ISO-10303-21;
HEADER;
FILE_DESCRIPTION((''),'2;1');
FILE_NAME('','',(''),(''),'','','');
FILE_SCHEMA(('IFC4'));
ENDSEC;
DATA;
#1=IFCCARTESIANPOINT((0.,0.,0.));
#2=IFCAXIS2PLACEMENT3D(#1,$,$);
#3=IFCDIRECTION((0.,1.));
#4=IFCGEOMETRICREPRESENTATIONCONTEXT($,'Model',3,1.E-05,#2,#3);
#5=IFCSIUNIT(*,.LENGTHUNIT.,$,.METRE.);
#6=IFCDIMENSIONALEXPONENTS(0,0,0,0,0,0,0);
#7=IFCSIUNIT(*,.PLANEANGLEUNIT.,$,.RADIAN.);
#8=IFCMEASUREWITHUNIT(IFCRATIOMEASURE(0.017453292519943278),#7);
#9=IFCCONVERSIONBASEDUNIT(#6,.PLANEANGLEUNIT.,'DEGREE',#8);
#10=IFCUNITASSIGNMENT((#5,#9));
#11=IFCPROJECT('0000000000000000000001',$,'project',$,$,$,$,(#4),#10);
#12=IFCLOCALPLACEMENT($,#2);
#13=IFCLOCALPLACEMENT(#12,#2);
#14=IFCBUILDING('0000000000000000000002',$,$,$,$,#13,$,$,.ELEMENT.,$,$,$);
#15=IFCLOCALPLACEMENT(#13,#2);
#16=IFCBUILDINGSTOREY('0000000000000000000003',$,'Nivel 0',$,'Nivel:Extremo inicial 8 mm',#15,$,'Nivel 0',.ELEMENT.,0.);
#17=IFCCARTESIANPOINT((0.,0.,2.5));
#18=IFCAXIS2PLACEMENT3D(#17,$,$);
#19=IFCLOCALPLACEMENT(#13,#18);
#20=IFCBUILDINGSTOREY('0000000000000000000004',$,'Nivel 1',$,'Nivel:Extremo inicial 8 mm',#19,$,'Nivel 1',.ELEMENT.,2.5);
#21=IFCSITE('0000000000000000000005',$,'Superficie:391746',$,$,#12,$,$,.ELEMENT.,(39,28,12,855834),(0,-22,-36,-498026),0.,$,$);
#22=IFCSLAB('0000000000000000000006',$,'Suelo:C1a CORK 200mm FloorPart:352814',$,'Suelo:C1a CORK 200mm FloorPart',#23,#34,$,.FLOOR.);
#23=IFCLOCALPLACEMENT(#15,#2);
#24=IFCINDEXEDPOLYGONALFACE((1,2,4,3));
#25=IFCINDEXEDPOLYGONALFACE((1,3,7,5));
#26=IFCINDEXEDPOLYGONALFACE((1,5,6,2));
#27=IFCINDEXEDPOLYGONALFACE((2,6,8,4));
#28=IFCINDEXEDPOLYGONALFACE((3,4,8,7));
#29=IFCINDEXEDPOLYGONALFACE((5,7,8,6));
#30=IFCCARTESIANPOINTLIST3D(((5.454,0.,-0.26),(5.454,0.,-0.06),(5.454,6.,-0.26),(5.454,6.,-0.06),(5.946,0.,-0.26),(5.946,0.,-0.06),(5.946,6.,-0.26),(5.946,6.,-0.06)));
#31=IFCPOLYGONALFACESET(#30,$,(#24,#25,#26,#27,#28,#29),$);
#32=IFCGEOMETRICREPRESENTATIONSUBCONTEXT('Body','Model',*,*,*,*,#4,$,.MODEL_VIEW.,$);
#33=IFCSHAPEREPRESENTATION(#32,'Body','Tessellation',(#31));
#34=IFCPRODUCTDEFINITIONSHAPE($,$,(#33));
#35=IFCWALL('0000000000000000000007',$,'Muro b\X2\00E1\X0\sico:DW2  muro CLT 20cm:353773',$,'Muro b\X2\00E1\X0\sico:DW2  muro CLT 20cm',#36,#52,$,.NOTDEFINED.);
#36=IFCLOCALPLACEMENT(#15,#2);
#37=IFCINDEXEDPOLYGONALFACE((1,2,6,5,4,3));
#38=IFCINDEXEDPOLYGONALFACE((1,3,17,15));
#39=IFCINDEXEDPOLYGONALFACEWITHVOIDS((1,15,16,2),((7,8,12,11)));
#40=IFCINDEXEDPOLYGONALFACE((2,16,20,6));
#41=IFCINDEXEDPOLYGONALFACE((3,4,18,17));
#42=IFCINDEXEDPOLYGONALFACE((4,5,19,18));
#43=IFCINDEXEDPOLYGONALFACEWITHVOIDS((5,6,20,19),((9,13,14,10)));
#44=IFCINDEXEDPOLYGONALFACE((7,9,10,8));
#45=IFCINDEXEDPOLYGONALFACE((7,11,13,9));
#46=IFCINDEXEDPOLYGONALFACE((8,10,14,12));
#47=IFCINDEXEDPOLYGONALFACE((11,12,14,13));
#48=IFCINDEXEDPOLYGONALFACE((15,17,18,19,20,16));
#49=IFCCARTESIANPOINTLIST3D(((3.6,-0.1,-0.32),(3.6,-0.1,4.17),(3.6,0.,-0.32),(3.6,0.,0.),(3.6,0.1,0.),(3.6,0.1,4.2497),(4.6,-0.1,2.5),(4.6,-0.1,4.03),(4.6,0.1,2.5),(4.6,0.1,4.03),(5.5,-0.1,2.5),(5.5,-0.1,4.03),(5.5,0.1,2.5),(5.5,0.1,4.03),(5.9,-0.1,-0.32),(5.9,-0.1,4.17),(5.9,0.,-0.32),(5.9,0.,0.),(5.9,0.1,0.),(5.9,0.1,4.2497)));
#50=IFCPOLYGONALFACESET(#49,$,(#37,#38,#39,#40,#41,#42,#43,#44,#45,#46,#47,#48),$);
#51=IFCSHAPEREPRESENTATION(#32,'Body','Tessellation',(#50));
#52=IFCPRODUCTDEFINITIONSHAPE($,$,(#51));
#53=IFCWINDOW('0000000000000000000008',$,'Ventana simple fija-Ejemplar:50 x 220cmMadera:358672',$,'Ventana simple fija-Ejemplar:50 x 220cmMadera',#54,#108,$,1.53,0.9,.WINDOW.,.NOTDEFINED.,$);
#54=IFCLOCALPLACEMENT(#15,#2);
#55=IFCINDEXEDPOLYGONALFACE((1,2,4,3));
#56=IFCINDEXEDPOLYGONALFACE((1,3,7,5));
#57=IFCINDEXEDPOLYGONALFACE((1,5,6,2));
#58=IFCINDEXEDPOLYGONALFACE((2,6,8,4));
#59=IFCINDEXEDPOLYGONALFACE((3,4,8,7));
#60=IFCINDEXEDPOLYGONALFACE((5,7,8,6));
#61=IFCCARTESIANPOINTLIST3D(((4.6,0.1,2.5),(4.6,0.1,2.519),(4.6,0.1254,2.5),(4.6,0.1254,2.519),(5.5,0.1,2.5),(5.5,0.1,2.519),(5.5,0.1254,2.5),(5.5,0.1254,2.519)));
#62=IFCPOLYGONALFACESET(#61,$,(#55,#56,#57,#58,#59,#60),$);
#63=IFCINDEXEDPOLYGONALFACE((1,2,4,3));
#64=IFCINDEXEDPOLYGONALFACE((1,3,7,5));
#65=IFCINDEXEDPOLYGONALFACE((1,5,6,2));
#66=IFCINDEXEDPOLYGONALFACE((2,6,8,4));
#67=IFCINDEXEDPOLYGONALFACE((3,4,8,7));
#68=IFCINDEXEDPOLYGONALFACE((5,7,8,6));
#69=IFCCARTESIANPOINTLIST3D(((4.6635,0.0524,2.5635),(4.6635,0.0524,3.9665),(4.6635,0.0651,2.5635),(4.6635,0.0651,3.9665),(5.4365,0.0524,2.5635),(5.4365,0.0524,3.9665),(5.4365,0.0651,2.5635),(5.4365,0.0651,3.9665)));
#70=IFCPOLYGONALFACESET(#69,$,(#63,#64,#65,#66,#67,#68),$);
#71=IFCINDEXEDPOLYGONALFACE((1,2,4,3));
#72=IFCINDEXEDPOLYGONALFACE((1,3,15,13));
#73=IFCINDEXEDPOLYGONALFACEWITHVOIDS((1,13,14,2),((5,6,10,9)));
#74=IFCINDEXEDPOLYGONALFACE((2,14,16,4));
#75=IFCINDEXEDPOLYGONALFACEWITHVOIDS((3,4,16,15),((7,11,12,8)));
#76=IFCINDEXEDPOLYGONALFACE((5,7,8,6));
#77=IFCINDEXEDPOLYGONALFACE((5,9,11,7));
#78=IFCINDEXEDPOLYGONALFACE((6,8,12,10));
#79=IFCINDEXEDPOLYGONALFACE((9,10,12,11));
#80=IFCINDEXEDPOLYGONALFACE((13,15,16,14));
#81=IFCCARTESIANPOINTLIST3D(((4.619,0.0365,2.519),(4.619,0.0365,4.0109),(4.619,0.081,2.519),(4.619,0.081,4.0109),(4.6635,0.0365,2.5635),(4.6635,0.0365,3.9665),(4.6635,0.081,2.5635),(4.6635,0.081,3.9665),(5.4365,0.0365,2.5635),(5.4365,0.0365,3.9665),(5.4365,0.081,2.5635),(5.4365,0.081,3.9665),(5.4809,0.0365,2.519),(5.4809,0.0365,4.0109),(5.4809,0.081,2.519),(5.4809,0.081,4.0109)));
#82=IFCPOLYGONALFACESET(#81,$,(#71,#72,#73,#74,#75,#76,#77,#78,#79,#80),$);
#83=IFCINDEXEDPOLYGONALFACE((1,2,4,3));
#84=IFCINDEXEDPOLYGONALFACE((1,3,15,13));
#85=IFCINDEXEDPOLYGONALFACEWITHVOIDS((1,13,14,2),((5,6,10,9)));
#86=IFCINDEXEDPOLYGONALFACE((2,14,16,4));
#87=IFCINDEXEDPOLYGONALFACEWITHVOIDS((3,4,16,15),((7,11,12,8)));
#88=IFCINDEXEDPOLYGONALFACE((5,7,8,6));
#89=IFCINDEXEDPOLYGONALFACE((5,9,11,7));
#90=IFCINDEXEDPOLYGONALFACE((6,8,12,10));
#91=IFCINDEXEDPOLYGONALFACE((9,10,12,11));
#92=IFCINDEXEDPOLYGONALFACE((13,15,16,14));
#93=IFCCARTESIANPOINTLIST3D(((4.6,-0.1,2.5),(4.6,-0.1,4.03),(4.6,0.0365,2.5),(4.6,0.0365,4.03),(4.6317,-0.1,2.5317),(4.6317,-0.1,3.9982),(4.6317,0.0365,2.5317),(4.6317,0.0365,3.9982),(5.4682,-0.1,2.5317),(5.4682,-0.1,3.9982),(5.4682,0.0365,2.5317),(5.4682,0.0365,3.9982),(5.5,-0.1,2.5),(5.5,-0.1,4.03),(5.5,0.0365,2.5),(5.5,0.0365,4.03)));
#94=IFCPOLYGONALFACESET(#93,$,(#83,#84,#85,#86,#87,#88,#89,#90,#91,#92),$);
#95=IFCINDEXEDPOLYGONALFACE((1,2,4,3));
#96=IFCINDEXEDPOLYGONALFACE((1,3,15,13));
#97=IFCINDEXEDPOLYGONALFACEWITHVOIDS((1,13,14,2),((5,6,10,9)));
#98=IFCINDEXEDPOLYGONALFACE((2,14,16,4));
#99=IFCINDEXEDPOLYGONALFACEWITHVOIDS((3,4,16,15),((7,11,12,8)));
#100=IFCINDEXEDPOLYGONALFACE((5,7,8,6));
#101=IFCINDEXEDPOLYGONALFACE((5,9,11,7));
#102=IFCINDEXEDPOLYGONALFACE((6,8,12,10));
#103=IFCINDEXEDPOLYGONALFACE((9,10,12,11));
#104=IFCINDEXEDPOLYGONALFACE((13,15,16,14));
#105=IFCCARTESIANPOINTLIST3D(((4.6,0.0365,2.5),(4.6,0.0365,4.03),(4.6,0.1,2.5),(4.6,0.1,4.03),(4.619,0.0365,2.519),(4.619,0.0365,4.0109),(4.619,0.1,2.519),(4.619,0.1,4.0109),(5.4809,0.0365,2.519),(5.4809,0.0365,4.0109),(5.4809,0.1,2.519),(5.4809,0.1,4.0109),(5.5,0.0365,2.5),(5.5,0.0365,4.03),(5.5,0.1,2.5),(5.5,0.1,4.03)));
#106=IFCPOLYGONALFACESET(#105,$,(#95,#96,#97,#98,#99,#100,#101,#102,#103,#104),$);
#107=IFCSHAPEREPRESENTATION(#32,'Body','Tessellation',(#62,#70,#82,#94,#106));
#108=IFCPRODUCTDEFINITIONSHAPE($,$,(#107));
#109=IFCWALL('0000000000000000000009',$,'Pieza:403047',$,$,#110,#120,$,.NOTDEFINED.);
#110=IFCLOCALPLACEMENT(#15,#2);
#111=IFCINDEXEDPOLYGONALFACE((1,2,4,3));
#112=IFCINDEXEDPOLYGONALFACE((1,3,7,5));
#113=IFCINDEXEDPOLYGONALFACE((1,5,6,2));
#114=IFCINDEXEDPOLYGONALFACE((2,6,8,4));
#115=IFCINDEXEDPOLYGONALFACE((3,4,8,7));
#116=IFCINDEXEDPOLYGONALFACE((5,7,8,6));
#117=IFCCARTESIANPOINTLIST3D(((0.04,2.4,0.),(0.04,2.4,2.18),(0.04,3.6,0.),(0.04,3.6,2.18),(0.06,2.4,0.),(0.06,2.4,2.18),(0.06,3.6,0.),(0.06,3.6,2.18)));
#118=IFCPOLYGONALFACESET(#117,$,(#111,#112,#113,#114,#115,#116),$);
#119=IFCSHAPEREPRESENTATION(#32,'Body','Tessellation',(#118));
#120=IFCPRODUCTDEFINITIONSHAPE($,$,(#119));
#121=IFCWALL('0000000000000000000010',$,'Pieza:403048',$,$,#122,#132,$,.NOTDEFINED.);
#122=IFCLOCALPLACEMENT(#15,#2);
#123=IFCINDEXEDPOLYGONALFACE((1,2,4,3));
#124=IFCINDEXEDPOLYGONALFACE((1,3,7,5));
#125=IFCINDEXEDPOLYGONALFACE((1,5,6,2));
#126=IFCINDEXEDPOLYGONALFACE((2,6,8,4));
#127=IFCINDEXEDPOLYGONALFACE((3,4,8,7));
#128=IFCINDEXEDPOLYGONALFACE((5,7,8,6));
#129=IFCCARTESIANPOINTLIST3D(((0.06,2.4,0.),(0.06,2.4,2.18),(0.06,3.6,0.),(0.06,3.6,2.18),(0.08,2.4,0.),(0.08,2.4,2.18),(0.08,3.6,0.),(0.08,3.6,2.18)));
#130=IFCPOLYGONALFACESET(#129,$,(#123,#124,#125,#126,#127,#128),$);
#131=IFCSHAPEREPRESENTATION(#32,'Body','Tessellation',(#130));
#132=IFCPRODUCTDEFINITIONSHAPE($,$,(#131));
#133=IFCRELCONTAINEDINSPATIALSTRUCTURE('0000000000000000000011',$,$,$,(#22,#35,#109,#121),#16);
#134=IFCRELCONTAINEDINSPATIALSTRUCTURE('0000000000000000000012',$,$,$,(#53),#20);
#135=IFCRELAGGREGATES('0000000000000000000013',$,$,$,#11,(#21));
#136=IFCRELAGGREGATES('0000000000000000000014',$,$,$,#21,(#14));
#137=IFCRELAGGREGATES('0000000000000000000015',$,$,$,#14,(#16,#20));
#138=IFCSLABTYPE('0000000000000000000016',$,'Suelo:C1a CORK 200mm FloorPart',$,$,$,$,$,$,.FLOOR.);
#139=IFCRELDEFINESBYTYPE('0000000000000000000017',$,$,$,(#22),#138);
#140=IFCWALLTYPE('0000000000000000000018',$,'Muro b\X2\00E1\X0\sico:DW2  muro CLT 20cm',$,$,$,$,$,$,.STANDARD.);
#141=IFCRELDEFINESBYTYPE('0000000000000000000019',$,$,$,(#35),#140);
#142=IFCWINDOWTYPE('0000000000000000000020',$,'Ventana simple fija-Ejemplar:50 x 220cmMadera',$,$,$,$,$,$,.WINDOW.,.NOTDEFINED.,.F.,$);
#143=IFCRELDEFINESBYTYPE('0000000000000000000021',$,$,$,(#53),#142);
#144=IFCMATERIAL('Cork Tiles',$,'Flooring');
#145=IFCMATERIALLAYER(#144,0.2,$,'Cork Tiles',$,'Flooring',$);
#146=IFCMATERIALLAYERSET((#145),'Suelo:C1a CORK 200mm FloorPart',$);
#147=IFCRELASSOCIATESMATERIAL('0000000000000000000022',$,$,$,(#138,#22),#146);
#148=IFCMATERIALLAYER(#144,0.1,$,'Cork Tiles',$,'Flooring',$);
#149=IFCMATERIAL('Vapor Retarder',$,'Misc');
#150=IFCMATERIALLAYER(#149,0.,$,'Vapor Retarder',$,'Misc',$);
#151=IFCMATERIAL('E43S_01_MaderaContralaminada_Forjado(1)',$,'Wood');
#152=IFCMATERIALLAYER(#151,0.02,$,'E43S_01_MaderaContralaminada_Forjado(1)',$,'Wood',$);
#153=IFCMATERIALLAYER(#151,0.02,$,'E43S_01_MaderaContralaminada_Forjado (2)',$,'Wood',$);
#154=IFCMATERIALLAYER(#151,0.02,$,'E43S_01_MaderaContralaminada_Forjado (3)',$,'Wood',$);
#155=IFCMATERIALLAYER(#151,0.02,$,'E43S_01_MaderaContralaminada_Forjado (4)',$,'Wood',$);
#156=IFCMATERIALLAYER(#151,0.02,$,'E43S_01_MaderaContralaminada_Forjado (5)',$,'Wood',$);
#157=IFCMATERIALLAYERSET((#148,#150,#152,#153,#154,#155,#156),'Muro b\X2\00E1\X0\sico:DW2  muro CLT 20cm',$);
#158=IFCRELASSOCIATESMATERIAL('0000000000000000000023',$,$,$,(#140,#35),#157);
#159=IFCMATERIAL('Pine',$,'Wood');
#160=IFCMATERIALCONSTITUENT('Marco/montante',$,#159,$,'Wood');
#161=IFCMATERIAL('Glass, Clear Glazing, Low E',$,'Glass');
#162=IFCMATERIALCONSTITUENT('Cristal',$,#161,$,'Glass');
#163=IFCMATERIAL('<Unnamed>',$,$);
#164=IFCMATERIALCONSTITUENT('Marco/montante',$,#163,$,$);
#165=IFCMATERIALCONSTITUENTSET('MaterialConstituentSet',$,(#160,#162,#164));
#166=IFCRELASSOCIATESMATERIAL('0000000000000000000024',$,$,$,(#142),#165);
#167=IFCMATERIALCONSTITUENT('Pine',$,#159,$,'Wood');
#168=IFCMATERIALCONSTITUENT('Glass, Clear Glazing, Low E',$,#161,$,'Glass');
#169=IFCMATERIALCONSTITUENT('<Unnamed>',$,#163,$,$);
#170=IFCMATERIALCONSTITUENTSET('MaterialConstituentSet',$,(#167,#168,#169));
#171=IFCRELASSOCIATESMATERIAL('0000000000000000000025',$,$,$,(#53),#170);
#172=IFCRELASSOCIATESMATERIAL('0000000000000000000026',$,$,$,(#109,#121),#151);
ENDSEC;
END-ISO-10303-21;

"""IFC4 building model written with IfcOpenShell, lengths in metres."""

from ifc_helpers import new_model, entity, si_unit, converted_unit, direction, frame, frame_2d, origin, origin_2d_with_axis, place, context, subcontext, project, spatial, polyline, rectangle, outline, extrude, clip, bounded_halfspace, source, transform, mapped, material, layer, layer_set, layer_usage, constituent, constituent_set, type_object, type_shapes, element, fill, save


model = new_model("IFC4")

# Units and contexts
model_context = context("Model", 3, precision=1e-05, world=origin(), true_north=direction((0.0, 1.0)))
body_context = subcontext(model_context, "Body", "Model", "MODEL_VIEW")
ifc_project = project(units=[si_unit("LENGTHUNIT", "METRE"), converted_unit("PLANEANGLEUNIT", "DEGREE", entity("IfcRatioMeasure", 0.017453292519943278), si_unit("PLANEANGLEUNIT", "RADIAN"), dimensions=[0, 0, 0, 0, 0, 0, 0])], contexts=[model_context])

# Site, building, storey
site_placement = place(None, origin())
site = spatial("IfcSite", under=ifc_project, at=site_placement, Name="Superficie:391746", CompositionType="ELEMENT", RefLatitude=(39, 28, 12, 855834), RefLongitude=(0, -22, -36, -498026), RefElevation=0.0)
building_placement = place(site_placement, origin())
building = spatial("IfcBuilding", under=site, at=building_placement, CompositionType="ELEMENT")
storey_1_placement = place(building_placement, origin())
storey_1 = spatial("IfcBuildingStorey", under=building, at=storey_1_placement, Name="Nivel 0", ObjectType="Nivel:Extremo inicial 8 mm", LongName="Nivel 0", CompositionType="ELEMENT", Elevation=0.0)

# Slab
ifc_material_1 = material(Name="E43S_01_MaderaContralaminada_Forjado(1)", Category="Wood")
ifc_material_2 = material(Name="Cork Tiles", Category="Flooring")
ifc_layer_1 = layer(ifc_material_2, 0.2, Name="Cork Tiles", Category="Flooring")
ifc_layer_set_1 = layer_set([ifc_layer_1], Name="Suelo:C1a CORK 200mm FloorPart")
ifc_layer_usage_1 = layer_usage(ifc_layer_set_1, "AXIS3", "POSITIVE", 0.0)
slab_type_1 = type_object("IfcSlabType", Name="Suelo:C1a CORK 200mm FloorPart", PredefinedType="FLOOR", material=ifc_layer_set_1)
slab_1_placement = place(storey_1_placement, origin())
element("IfcSlab", 1, at=slab_1_placement, inside=storey_1, type_object=slab_type_1, material=ifc_layer_usage_1, Name="Suelo:C1a CORK 200mm FloorPart:352814", ObjectType="Suelo:C1a CORK 200mm FloorPart", PredefinedType="FLOOR", context=body_context, shape_type="SweptSolid", body=[
    extrude(rectangle(XDim=6.0, YDim=0.492, at=frame_2d((0.0, 0.0), x_axis=(1.0, 0.0))), frame((5.7, 3.0, -0.06), z_axis=(0.0, 0.0, -1.0), x_axis=(0.0, 1.0, 0.0)), (0.0, 0.0, 1.0), 0.2),
])

# Wall, openings
ifc_layer_2 = layer(ifc_material_2, 0.1, Name="Cork Tiles", Category="Flooring")
ifc_material_3 = material(Name="Vapor Retarder", Category="Misc")
ifc_layer_3 = layer(ifc_material_3, 0.0, Name="Vapor Retarder", Category="Misc")
ifc_layer_4 = layer(ifc_material_1, 0.02, Name="E43S_01_MaderaContralaminada_Forjado(1)", Category="Wood")
ifc_layer_5 = layer(ifc_material_1, 0.02, Name="E43S_01_MaderaContralaminada_Forjado (2)", Category="Wood")
ifc_layer_6 = layer(ifc_material_1, 0.02, Name="E43S_01_MaderaContralaminada_Forjado (3)", Category="Wood")
ifc_layer_7 = layer(ifc_material_1, 0.02, Name="E43S_01_MaderaContralaminada_Forjado (4)", Category="Wood")
ifc_layer_8 = layer(ifc_material_1, 0.02, Name="E43S_01_MaderaContralaminada_Forjado (5)", Category="Wood")
ifc_layer_set_2 = layer_set([ifc_layer_2, ifc_layer_3, ifc_layer_4, ifc_layer_5, ifc_layer_6, ifc_layer_7, ifc_layer_8], Name="Muro básico:DW2  muro CLT 20cm")
ifc_layer_usage_2 = layer_usage(ifc_layer_set_2, "AXIS2", "NEGATIVE", 0.1)
wall_type = type_object("IfcWallType", Name="Muro básico:DW2  muro CLT 20cm", PredefinedType="STANDARD", material=ifc_layer_set_2)
wall_1_placement = place(storey_1_placement, frame((5.9, 0.0, -0.32), z_axis=(0.0, 0.0, 1.0), x_axis=(-1.0, 0.0, 0.0)))
wall_1 = element("IfcWall", 2, at=wall_1_placement, inside=storey_1, type_object=wall_type, material=ifc_layer_usage_2, Name="Muro básico:DW2  muro CLT 20cm:353773", ObjectType="Muro básico:DW2  muro CLT 20cm", PredefinedType="NOTDEFINED", context=body_context, shape_type="Clipping", body=[
    clip(clip(extrude(rectangle(XDim=2.3, YDim=0.2, at=frame_2d((1.15, 0.0), x_axis=(1.0, 0.0))), origin(), (0.0, 0.0, 1.0), 4.5697), bounded_halfspace(frame((0.0, -0.1, 4.5697), z_axis=(0.0, 0.370288, 0.928917), x_axis=(-1.0, 0.0, 0.0)), False, frame((0.0, -0.1, 4.5697)), polyline([(0.0, 0.0), (2.3, 0.0), (2.3, 0.2), (0.0, 0.2), (0.0, 0.0)]))), bounded_halfspace(frame((2.3, -0.1, 0.32), z_axis=(0.0, 0.0, -1.0), x_axis=(0.0, 1.0, 0.0)), False, frame((2.3, -0.1, 0.32)), polyline([(0.0, 0.0), (0.0, 0.1), (-2.3, 0.1), (-2.3, 0.0), (0.0, 0.0)]))),
])
opening_1_placement = place(wall_1_placement, frame((5.4, 1.624, 0.32)))
element("IfcOpeningElement", 3, at=opening_1_placement, cuts=wall_1, PredefinedType="OPENING", context=body_context, shape_type="SweptSolid", body=[
    extrude(rectangle(XDim=2.1, YDim=1.4, at=origin_2d_with_axis()), frame((-0.7, -3.048, 1.05), z_axis=(0.0, 1.0, 0.0), x_axis=(0.0, 0.0, -1.0)), (0.0, 0.0, 1.0), 3.048),
])
opening_2_placement = place(wall_1_placement, frame((1.3, 0.1, 2.82)))
opening_2 = element("IfcOpeningElement", 4, at=opening_2_placement, cuts=wall_1, PredefinedType="OPENING", context=body_context, shape_type="SweptSolid", body=[
    extrude(rectangle(XDim=1.53, YDim=0.9, at=frame_2d((0.765, 0.45), x_axis=(-1.0, 0.0))), frame((0.0, 0.0, 0.0), z_axis=(0.0, -1.0, 0.0), x_axis=(0.0, 0.0, 1.0)), (0.0, 0.0, 1.0), 0.2),
])

# Shared definitions
storey_2_placement = place(building_placement, frame((0.0, 0.0, 2.5)))
storey_2 = spatial("IfcBuildingStorey", under=building, at=storey_2_placement, Name="Nivel 1", ObjectType="Nivel:Extremo inicial 8 mm", LongName="Nivel 1", CompositionType="ELEMENT", Elevation=2.5)

# Window
ifc_material_4 = material(Name="Pine", Category="Wood")
ifc_constituent_1 = constituent(ifc_material_4, Name="Pine", Category="Wood")
ifc_material_5 = material(Name="Glass, Clear Glazing, Low E", Category="Glass")
ifc_constituent_2 = constituent(ifc_material_5, Name="Glass, Clear Glazing, Low E", Category="Glass")
ifc_material_6 = material(Name="<Unnamed>")
ifc_constituent_3 = constituent(ifc_material_6, Name="<Unnamed>")
ifc_constituent_set_1 = constituent_set(constituents=[ifc_constituent_1, ifc_constituent_2, ifc_constituent_3], Name="MaterialConstituentSet")
ifc_constituent_4 = constituent(ifc_material_4, Name="Marco/montante", Category="Wood")
ifc_constituent_5 = constituent(ifc_material_5, Name="Cristal", Category="Glass")
ifc_constituent_6 = constituent(ifc_material_6, Name="Marco/montante")
ifc_constituent_set_2 = constituent_set(constituents=[ifc_constituent_4, ifc_constituent_5, ifc_constituent_6], Name="MaterialConstituentSet")
window_type = type_object("IfcWindowType", Name="Ventana simple fija-Ejemplar:50 x 220cmMadera", ParameterTakesPrecedence=False, PartitioningType="NOTDEFINED", PredefinedType="WINDOW", material=ifc_constituent_set_2)
shared_shape_1 = source(origin(), body_context, "Body", "SweptSolid", [
    extrude(rectangle(XDim=0.9, YDim=0.0254, at=origin_2d_with_axis()), frame((0.5262, 0.2127, 0.0), z_axis=(0.0, 0.0, 1.0), x_axis=(-1.0, 0.0, 0.0)), (0.0, 0.0, 1.0), 0.019),
    extrude(rectangle(XDim=0.773, YDim=0.0127, at=frame_2d((0.0, 0.0), x_axis=(1.0, 0.0))), frame((0.5262, 0.1588, 0.0635)), (0.0, 0.0, 1.0), 1.403),
    extrude(outline(polyline([(-0.431, -0.7459), (0.431, -0.7459), (0.431, 0.7459), (-0.431, 0.7459), (-0.431, -0.7459)]), holes=[polyline([(-0.3865, -0.7015), (-0.3865, 0.7015), (0.3865, 0.7015), (0.3865, -0.7015), (-0.3865, -0.7015)])]), frame((0.5262, 0.181, 0.765), z_axis=(0.0, -1.0, 0.0), x_axis=(-1.0, 0.0, 0.0)), (0.0, 0.0, 1.0), 0.0444),
    extrude(outline(polyline([(-0.45, -0.765), (0.45, -0.765), (0.45, 0.765), (-0.45, 0.765), (-0.45, -0.765)]), holes=[polyline([(-0.4183, -0.7332), (-0.4183, 0.7332), (0.4183, 0.7332), (0.4183, -0.7332), (-0.4183, -0.7332)])]), frame((0.5262, 0.1365, 0.765), z_axis=(0.0, -1.0, 0.0), x_axis=(-1.0, 0.0, 0.0)), (0.0, 0.0, 1.0), 0.1365),
    extrude(outline(polyline([(-0.765, -0.45), (0.765, -0.45), (0.765, 0.45), (-0.765, 0.45), (-0.765, -0.45)]), holes=[polyline([(-0.7459, -0.431), (-0.7459, 0.431), (0.7459, 0.431), (0.7459, -0.431), (-0.7459, -0.431)])]), frame((0.5262, 0.2, 0.765), z_axis=(0.0, -1.0, 0.0), x_axis=(0.0, 0.0, -1.0)), (0.0, 0.0, 1.0), 0.0635),
])
type_shapes(window_type, [shared_shape_1])
window_placement = place(opening_2_placement, frame((0.0762, 0.0, 0.0), z_axis=(0.0, 0.0, 1.0), x_axis=(-1.0, 0.0, 0.0)))
window = element("IfcWindow", 5, at=window_placement, inside=storey_2, type_object=window_type, material=ifc_constituent_set_1, Name="Ventana simple fija-Ejemplar:50 x 220cmMadera:358672", ObjectType="Ventana simple fija-Ejemplar:50 x 220cmMadera", OverallHeight=1.53, OverallWidth=0.9, PartitioningType="NOTDEFINED", PredefinedType="WINDOW", context=body_context, shape_type="MappedRepresentation", body=[
    mapped(shared_shape_1, transform((0.0, 0.0, 0.0), scale=1.0)),
])
fill(opening_2, window)

# Walls
wall_2_placement = place(storey_1_placement, frame((0.04, 2.4, 0.0)))
element("IfcWall", 6, at=wall_2_placement, inside=storey_1, material=ifc_material_1, Name="Pieza:403047", PredefinedType="NOTDEFINED", context=body_context, shape_type="SweptSolid", body=[
    extrude(rectangle(XDim=1.2, YDim=0.02, at=frame_2d((0.0, 0.0), x_axis=(1.0, 0.0))), frame((0.01, 0.6, 0.0), z_axis=(0.0, 0.0, 1.0), x_axis=(0.0, -1.0, 0.0)), (0.0, 0.0, 1.0), 2.18),
])
wall_3_placement = place(storey_1_placement, frame((0.06, 2.4, 0.0)))
element("IfcWall", 7, at=wall_3_placement, inside=storey_1, material=ifc_material_1, Name="Pieza:403048", PredefinedType="NOTDEFINED", context=body_context, shape_type="SweptSolid", body=[
    extrude(rectangle(XDim=1.2, YDim=0.02, at=frame_2d((0.0, 0.0), x_axis=(1.0, 0.0))), frame((0.01, 0.6, 0.0), z_axis=(0.0, 0.0, 1.0), x_axis=(0.0, -1.0, 0.0)), (0.0, 0.0, 1.0), 2.18),
])

save(model, "model.ifc")
